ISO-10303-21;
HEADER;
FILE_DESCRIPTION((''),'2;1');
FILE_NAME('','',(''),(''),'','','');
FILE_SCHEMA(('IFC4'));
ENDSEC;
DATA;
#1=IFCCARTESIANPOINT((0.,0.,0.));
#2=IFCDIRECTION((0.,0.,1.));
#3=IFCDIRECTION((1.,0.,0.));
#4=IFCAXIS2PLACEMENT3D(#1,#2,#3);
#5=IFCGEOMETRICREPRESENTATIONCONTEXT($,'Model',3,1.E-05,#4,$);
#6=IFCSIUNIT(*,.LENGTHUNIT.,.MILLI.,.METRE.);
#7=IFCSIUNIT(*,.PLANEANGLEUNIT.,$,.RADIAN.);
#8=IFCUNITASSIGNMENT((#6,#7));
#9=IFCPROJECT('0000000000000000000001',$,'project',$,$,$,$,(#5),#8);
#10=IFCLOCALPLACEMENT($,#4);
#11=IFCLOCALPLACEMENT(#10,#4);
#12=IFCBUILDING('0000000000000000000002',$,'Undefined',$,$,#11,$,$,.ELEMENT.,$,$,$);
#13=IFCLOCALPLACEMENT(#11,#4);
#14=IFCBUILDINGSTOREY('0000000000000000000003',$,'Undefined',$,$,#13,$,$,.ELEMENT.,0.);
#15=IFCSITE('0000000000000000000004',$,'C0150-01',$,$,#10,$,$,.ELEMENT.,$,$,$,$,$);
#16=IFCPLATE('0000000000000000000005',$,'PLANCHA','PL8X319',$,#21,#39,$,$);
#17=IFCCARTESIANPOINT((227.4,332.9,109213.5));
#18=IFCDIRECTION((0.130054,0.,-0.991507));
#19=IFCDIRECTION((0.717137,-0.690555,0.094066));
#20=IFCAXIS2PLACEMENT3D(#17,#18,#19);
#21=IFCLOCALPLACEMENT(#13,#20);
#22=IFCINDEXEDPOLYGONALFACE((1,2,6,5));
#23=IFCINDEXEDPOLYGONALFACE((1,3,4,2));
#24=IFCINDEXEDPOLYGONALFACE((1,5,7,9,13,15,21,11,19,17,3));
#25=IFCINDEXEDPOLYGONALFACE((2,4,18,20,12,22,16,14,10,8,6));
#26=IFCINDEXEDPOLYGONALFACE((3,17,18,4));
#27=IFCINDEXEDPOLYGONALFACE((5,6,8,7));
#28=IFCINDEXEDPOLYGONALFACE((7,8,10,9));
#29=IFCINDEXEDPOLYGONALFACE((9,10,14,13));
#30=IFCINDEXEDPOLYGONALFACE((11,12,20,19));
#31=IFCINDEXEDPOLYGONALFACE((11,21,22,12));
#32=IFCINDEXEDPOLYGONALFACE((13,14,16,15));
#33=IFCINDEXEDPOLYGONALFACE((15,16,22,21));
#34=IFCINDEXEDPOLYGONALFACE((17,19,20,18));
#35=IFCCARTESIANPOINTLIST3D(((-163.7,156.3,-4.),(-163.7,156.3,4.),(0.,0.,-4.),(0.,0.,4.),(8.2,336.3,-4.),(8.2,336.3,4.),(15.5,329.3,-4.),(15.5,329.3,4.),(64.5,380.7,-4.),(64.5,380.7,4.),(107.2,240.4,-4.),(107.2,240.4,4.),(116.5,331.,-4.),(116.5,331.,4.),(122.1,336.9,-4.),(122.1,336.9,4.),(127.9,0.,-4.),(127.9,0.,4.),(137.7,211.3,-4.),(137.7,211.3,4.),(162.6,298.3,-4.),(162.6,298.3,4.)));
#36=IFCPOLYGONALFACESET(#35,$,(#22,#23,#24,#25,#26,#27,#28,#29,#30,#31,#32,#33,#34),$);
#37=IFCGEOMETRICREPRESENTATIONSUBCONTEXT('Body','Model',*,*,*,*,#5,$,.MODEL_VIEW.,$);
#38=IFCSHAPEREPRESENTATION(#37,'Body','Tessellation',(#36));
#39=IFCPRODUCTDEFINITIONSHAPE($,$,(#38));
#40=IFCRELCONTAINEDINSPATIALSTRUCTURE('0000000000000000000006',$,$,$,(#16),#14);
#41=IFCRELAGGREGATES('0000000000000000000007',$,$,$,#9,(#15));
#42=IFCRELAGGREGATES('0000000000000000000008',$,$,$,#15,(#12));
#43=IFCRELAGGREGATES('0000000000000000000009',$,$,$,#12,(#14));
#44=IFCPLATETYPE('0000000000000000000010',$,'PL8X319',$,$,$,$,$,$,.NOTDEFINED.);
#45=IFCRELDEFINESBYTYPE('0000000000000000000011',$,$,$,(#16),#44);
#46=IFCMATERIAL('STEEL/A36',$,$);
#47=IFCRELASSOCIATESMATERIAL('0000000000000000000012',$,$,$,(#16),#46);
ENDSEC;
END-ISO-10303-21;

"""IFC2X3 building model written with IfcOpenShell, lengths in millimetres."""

from ifc_helpers import new_model, si_unit, frame, origin_with_axes, place, context, subcontext, project, spatial, polyline, outline, extrude, material, type_object, element, save


model = new_model("IFC2X3")

# Units and contexts
model_context = context("Model", 3, precision=1e-05, world=origin_with_axes())
body_context = subcontext(model_context, "Body", "Model", "MODEL_VIEW")
ifc_project = project(units=[si_unit("LENGTHUNIT", "METRE", prefix="MILLI"), si_unit("PLANEANGLEUNIT", "RADIAN")], contexts=[model_context])

# Site, building, storey
site_placement = place(None, origin_with_axes())
site = spatial("IfcSite", under=ifc_project, at=site_placement, Name="C0150-01", CompositionType="ELEMENT")
building_placement = place(site_placement, origin_with_axes())
building = spatial("IfcBuilding", under=site, at=building_placement, Name="Undefined", CompositionType="ELEMENT")
storey_placement = place(building_placement, origin_with_axes())
storey = spatial("IfcBuildingStorey", under=building, at=storey_placement, Name="Undefined", CompositionType="ELEMENT", Elevation=0.0)

# Shared definitions
ifc_material_1 = material(Name="STEEL/A36")

# Plate
plate_type_1 = type_object("IfcPlateType", Name="PL8X319", PredefinedType="NOTDEFINED")
plate_1_placement = place(storey_placement, frame((227.4, 332.9, 109213.5), z_axis=(0.130054, 0.0, -0.991507), x_axis=(0.717137, -0.690555, 0.094066)))
element("IfcPlate", 1, at=plate_1_placement, inside=storey, type_object=plate_type_1, material=ifc_material_1, Name="PLANCHA", Description="PL8X319", context=body_context, shape_type="SweptSolid", body=[
    extrude(outline(polyline([(0.0, 0.0), (127.9, 0.0), (137.7, 211.3), (107.2, 240.4), (162.6, 298.3), (122.1, 336.9), (116.5, 331.0), (64.5, 380.7), (15.5, 329.3), (8.2, 336.3), (-163.7, 156.3), (0.0, 0.0)])), frame((0.0, 0.0, -4.0), z_axis=(0.0, 0.0, 1.0), x_axis=(1.0, 0.0, 0.0)), (0.0, 0.0, 1.0), 8.0),
])

save(model, "model.ifc")
